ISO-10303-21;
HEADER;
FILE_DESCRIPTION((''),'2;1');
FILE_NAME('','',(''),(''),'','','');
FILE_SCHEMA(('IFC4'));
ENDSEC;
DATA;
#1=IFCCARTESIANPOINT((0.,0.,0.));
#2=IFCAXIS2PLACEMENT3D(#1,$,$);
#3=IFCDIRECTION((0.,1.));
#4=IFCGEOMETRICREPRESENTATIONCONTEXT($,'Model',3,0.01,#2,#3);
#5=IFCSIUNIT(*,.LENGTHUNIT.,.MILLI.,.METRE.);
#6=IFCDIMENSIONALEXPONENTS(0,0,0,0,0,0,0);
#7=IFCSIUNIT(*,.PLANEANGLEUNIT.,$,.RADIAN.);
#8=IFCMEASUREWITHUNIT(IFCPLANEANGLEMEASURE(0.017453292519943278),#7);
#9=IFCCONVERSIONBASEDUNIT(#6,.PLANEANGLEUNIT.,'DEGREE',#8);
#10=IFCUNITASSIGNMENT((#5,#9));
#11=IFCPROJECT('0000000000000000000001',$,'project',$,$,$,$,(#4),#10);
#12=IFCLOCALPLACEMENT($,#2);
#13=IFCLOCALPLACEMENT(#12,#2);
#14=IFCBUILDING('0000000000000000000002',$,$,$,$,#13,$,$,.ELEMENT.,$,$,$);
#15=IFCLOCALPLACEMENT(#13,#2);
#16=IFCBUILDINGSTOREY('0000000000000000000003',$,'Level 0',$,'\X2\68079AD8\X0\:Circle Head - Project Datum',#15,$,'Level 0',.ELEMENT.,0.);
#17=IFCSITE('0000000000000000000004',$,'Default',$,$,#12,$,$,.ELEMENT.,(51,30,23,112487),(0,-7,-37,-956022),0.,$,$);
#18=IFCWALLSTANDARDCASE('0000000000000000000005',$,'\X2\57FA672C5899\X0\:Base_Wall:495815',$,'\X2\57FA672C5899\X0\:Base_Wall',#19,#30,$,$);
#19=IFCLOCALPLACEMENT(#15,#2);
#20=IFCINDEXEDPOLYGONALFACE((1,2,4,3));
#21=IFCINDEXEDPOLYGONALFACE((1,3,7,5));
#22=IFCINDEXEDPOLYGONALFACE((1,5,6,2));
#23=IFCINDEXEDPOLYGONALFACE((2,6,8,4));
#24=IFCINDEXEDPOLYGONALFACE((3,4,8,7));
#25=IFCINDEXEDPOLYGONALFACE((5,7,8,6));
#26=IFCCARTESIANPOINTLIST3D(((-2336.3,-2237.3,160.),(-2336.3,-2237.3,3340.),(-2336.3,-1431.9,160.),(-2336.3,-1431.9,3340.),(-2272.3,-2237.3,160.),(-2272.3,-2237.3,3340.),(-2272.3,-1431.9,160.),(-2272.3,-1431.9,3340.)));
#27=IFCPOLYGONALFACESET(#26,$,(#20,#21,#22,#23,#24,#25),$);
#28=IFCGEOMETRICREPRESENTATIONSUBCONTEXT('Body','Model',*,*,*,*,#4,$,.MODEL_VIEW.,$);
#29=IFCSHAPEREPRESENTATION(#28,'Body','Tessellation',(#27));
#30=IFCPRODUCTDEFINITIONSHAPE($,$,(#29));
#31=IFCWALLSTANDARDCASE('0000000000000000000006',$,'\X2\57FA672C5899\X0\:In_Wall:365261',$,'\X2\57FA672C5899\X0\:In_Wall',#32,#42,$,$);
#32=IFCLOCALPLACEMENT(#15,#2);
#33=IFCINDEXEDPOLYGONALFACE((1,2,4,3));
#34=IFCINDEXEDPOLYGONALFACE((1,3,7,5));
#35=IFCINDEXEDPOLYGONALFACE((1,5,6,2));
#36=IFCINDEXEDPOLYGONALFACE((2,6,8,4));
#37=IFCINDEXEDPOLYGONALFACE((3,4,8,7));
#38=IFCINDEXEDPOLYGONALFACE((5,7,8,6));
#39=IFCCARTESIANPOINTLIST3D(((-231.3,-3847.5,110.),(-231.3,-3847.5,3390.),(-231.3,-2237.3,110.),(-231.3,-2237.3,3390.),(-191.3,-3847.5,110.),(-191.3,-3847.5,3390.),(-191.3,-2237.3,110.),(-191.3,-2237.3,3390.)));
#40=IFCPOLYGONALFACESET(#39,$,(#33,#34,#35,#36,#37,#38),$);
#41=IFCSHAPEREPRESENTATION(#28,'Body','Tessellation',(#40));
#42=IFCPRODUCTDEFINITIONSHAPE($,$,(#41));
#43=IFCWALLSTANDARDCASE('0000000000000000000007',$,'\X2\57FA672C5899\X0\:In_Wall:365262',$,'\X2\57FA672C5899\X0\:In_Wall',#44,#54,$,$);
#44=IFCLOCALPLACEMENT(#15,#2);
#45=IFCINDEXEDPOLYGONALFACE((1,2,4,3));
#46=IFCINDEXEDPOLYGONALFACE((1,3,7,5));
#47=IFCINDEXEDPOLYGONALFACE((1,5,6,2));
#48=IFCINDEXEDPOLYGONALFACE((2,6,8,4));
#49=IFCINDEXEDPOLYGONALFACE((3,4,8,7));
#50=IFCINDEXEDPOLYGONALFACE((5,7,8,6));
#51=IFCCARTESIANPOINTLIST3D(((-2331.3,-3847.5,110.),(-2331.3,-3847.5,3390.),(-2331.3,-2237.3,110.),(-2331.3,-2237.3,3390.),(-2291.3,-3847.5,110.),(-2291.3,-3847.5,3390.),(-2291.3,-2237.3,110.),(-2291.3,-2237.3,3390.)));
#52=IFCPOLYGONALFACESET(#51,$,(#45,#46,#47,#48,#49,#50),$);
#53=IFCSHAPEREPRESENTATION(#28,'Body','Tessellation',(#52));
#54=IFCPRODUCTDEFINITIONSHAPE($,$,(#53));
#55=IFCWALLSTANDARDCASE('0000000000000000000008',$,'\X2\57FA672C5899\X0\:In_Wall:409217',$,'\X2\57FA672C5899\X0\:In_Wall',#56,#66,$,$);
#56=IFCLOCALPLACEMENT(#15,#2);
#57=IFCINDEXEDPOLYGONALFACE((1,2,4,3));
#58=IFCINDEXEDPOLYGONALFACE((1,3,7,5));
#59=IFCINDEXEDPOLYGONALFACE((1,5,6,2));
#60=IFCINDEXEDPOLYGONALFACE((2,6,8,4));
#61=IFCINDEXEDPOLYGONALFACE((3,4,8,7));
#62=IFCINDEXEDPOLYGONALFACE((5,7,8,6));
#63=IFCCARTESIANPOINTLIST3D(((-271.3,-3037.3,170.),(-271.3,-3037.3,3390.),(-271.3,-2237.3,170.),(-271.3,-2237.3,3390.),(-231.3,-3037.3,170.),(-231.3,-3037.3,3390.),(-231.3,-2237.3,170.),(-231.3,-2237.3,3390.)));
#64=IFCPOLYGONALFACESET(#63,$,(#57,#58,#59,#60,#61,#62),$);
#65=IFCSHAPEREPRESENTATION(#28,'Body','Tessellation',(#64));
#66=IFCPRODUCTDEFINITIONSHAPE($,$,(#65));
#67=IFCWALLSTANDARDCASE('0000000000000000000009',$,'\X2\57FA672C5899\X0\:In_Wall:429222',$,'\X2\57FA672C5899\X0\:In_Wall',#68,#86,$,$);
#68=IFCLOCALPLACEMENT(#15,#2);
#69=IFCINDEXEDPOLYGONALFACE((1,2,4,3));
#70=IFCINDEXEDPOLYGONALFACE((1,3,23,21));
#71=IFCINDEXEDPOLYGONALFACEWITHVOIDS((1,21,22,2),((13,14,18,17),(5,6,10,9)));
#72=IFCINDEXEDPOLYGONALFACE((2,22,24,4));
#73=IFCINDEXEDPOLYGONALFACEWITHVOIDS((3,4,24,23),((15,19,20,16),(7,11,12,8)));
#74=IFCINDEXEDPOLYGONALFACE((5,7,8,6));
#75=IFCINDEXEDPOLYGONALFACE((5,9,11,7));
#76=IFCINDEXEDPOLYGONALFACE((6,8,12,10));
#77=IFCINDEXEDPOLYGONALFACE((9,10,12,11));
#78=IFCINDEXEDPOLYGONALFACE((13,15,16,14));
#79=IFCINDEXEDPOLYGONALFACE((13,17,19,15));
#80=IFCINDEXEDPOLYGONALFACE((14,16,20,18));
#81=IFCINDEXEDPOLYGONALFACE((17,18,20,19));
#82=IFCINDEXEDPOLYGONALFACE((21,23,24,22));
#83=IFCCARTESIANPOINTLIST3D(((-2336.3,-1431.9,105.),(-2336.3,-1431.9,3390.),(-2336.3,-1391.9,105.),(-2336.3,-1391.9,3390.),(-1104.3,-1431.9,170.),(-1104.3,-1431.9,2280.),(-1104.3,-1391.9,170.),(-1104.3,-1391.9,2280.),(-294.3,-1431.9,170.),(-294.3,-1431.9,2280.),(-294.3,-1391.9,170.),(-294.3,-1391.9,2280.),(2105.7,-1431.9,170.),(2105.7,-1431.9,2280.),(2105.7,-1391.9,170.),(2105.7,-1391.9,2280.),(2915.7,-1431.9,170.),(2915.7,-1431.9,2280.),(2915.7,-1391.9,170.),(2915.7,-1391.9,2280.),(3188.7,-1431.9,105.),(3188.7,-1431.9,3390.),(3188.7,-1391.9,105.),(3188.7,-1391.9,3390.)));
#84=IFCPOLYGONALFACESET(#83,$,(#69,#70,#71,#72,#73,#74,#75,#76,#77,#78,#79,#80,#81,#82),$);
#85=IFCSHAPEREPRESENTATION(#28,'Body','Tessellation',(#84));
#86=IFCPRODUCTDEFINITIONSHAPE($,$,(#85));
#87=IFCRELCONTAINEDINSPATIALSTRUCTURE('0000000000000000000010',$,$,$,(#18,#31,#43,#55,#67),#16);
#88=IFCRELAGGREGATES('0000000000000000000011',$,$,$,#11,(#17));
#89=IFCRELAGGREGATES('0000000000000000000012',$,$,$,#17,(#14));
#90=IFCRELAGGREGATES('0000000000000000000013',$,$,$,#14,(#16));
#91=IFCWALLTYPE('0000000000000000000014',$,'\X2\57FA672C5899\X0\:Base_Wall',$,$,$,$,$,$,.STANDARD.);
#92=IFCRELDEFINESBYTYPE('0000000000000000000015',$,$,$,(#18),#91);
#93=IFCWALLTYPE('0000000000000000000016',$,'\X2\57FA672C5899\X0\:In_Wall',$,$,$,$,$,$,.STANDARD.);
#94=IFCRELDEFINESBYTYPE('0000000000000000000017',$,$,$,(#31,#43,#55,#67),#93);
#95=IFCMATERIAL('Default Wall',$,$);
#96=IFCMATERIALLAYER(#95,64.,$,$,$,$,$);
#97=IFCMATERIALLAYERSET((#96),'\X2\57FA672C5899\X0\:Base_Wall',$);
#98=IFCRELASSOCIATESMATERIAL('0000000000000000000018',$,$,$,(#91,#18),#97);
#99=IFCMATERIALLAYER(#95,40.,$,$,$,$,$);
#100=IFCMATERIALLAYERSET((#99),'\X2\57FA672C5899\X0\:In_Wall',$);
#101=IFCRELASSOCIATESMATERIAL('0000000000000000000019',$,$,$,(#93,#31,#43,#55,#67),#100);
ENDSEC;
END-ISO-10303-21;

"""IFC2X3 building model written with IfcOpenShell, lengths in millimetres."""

from ifc_helpers import new_model, entity, si_unit, converted_unit, direction, frame, frame_2d, origin, place, context, subcontext, project, spatial, rectangle, extrude, material, layer, layer_set, layer_usage, type_object, element, save


model = new_model("IFC2X3")

# Units and contexts
model_context = context("Model", 3, precision=0.01, world=origin(), true_north=direction((0.0, 1.0)))
body_context = subcontext(model_context, "Body", "Model", "MODEL_VIEW")
ifc_project = project(units=[si_unit("LENGTHUNIT", "METRE", prefix="MILLI"), converted_unit("PLANEANGLEUNIT", "DEGREE", entity("IfcPlaneAngleMeasure", 0.017453292519943278), si_unit("PLANEANGLEUNIT", "RADIAN"), dimensions=[0, 0, 0, 0, 0, 0, 0])], contexts=[model_context])

# Site, building, storey
site_placement = place(None, origin())
site = spatial("IfcSite", under=ifc_project, at=site_placement, Name="Default", CompositionType="ELEMENT", RefLatitude=(51, 30, 23, 112487), RefLongitude=(0, -7, -37, -956022), RefElevation=0.0)
building_placement = place(site_placement, origin())
building = spatial("IfcBuilding", under=site, at=building_placement, CompositionType="ELEMENT")
storey_placement = place(building_placement, origin())
storey = spatial("IfcBuildingStorey", under=building, at=storey_placement, Name="Level 0", ObjectType="标高:Circle Head - Project Datum", LongName="Level 0", CompositionType="ELEMENT", Elevation=0.0)

# Walls
ifc_material_1 = material(Name="Default Wall")
ifc_layer_1 = layer(ifc_material_1, 64.0)
ifc_layer_set_1 = layer_set([ifc_layer_1], Name="基本墙:Base_Wall")
wall_type_1 = type_object("IfcWallType", Name="基本墙:Base_Wall", PredefinedType="STANDARD", material=ifc_layer_set_1)
ifc_layer_usage_1 = layer_usage(ifc_layer_set_1, "AXIS2", "NEGATIVE", 32.0)
wall_1_placement = place(storey_placement, frame((-2304.3, -1431.9, 160.0), z_axis=(0.0, 0.0, 1.0), x_axis=(0.0, -1.0, 0.0)))
element("IfcWallStandardCase", 1, at=wall_1_placement, inside=storey, type_object=wall_type_1, material=ifc_layer_usage_1, Name="基本墙:Base_Wall:495815", ObjectType="基本墙:Base_Wall", context=body_context, shape_type="SweptSolid", body=[
    extrude(rectangle(XDim=805.4, YDim=64.0, at=frame_2d((402.7, 0.0), x_axis=(-1.0, 0.0))), origin(), (0.0, 0.0, 1.0), 3180.0),
])
ifc_layer_2 = layer(ifc_material_1, 40.0)
ifc_layer_set_2 = layer_set([ifc_layer_2], Name="基本墙:In_Wall")
ifc_layer_usage_2 = layer_usage(ifc_layer_set_2, "AXIS2", "NEGATIVE", 20.0)
wall_type_2 = type_object("IfcWallType", Name="基本墙:In_Wall", PredefinedType="STANDARD", material=ifc_layer_set_2)
wall_2_placement = place(storey_placement, frame((-211.3, -2237.3, 110.0), z_axis=(0.0, 0.0, 1.0), x_axis=(0.0, -1.0, 0.0)))
element("IfcWallStandardCase", 2, at=wall_2_placement, inside=storey, type_object=wall_type_2, material=ifc_layer_usage_2, Name="基本墙:In_Wall:365261", ObjectType="基本墙:In_Wall", context=body_context, shape_type="SweptSolid", body=[
    extrude(rectangle(XDim=1610.2, YDim=40.0, at=frame_2d((805.1, 0.0), x_axis=(-1.0, 0.0))), origin(), (0.0, 0.0, 1.0), 3280.0),
])
ifc_layer_usage_3 = layer_usage(ifc_layer_set_2, "AXIS2", "NEGATIVE", 20.0)
wall_3_placement = place(storey_placement, frame((-2311.3, -2237.3, 110.0), z_axis=(0.0, 0.0, 1.0), x_axis=(0.0, -1.0, 0.0)))
element("IfcWallStandardCase", 3, at=wall_3_placement, inside=storey, type_object=wall_type_2, material=ifc_layer_usage_3, Name="基本墙:In_Wall:365262", ObjectType="基本墙:In_Wall", context=body_context, shape_type="SweptSolid", body=[
    extrude(rectangle(XDim=1610.2, YDim=40.0, at=frame_2d((805.1, 0.0), x_axis=(-1.0, 0.0))), origin(), (0.0, 0.0, 1.0), 3280.0),
])
ifc_layer_usage_4 = layer_usage(ifc_layer_set_2, "AXIS2", "NEGATIVE", 20.0)
wall_4_placement = place(storey_placement, frame((-251.3, -3037.3, 170.0), z_axis=(0.0, 0.0, 1.0), x_axis=(0.0, 1.0, 0.0)))
element("IfcWallStandardCase", 4, at=wall_4_placement, inside=storey, type_object=wall_type_2, material=ifc_layer_usage_4, Name="基本墙:In_Wall:409217", ObjectType="基本墙:In_Wall", context=body_context, shape_type="SweptSolid", body=[
    extrude(rectangle(XDim=800.0, YDim=40.0, at=frame_2d((400.0, 0.0), x_axis=(-1.0, 0.0))), origin(), (0.0, 0.0, 1.0), 3220.0),
])

# Wall, openings
ifc_layer_usage_5 = layer_usage(ifc_layer_set_2, "AXIS2", "NEGATIVE", 20.0)
wall_5_placement = place(storey_placement, frame((-2336.3, -1411.9, 105.0)))
wall_5 = element("IfcWallStandardCase", 5, at=wall_5_placement, inside=storey, type_object=wall_type_2, material=ifc_layer_usage_5, Name="基本墙:In_Wall:429222", ObjectType="基本墙:In_Wall", context=body_context, shape_type="SweptSolid", body=[
    extrude(rectangle(XDim=5525.0, YDim=40.0, at=frame_2d((2762.5, 0.0), x_axis=(-1.0, 0.0))), origin(), (0.0, 0.0, 1.0), 3285.0),
])
opening_1_placement = place(wall_5_placement, frame((2042.0, 20.0, 65.0)))
element("IfcOpeningElement", 6, at=opening_1_placement, cuts=wall_5, ObjectType="Opening", context=body_context, shape_type="SweptSolid", body=[
    extrude(rectangle(XDim=2110.0, YDim=810.0, at=frame_2d((1055.0, 405.0), x_axis=(1.0, 0.0))), frame((0.0, 0.0, 0.0), z_axis=(0.0, -1.0, 0.0), x_axis=(0.0, 0.0, 1.0)), (0.0, 0.0, 1.0), 40.0),
])
opening_2_placement = place(wall_5_placement, frame((5252.0, 20.0, 65.0)))
element("IfcOpeningElement", 7, at=opening_2_placement, cuts=wall_5, ObjectType="Opening", context=body_context, shape_type="SweptSolid", body=[
    extrude(rectangle(XDim=2110.0, YDim=810.0, at=frame_2d((1055.0, 405.0), x_axis=(1.0, 0.0))), frame((0.0, 0.0, 0.0), z_axis=(0.0, -1.0, 0.0), x_axis=(0.0, 0.0, 1.0)), (0.0, 0.0, 1.0), 40.0),
])

save(model, "model.ifc")
